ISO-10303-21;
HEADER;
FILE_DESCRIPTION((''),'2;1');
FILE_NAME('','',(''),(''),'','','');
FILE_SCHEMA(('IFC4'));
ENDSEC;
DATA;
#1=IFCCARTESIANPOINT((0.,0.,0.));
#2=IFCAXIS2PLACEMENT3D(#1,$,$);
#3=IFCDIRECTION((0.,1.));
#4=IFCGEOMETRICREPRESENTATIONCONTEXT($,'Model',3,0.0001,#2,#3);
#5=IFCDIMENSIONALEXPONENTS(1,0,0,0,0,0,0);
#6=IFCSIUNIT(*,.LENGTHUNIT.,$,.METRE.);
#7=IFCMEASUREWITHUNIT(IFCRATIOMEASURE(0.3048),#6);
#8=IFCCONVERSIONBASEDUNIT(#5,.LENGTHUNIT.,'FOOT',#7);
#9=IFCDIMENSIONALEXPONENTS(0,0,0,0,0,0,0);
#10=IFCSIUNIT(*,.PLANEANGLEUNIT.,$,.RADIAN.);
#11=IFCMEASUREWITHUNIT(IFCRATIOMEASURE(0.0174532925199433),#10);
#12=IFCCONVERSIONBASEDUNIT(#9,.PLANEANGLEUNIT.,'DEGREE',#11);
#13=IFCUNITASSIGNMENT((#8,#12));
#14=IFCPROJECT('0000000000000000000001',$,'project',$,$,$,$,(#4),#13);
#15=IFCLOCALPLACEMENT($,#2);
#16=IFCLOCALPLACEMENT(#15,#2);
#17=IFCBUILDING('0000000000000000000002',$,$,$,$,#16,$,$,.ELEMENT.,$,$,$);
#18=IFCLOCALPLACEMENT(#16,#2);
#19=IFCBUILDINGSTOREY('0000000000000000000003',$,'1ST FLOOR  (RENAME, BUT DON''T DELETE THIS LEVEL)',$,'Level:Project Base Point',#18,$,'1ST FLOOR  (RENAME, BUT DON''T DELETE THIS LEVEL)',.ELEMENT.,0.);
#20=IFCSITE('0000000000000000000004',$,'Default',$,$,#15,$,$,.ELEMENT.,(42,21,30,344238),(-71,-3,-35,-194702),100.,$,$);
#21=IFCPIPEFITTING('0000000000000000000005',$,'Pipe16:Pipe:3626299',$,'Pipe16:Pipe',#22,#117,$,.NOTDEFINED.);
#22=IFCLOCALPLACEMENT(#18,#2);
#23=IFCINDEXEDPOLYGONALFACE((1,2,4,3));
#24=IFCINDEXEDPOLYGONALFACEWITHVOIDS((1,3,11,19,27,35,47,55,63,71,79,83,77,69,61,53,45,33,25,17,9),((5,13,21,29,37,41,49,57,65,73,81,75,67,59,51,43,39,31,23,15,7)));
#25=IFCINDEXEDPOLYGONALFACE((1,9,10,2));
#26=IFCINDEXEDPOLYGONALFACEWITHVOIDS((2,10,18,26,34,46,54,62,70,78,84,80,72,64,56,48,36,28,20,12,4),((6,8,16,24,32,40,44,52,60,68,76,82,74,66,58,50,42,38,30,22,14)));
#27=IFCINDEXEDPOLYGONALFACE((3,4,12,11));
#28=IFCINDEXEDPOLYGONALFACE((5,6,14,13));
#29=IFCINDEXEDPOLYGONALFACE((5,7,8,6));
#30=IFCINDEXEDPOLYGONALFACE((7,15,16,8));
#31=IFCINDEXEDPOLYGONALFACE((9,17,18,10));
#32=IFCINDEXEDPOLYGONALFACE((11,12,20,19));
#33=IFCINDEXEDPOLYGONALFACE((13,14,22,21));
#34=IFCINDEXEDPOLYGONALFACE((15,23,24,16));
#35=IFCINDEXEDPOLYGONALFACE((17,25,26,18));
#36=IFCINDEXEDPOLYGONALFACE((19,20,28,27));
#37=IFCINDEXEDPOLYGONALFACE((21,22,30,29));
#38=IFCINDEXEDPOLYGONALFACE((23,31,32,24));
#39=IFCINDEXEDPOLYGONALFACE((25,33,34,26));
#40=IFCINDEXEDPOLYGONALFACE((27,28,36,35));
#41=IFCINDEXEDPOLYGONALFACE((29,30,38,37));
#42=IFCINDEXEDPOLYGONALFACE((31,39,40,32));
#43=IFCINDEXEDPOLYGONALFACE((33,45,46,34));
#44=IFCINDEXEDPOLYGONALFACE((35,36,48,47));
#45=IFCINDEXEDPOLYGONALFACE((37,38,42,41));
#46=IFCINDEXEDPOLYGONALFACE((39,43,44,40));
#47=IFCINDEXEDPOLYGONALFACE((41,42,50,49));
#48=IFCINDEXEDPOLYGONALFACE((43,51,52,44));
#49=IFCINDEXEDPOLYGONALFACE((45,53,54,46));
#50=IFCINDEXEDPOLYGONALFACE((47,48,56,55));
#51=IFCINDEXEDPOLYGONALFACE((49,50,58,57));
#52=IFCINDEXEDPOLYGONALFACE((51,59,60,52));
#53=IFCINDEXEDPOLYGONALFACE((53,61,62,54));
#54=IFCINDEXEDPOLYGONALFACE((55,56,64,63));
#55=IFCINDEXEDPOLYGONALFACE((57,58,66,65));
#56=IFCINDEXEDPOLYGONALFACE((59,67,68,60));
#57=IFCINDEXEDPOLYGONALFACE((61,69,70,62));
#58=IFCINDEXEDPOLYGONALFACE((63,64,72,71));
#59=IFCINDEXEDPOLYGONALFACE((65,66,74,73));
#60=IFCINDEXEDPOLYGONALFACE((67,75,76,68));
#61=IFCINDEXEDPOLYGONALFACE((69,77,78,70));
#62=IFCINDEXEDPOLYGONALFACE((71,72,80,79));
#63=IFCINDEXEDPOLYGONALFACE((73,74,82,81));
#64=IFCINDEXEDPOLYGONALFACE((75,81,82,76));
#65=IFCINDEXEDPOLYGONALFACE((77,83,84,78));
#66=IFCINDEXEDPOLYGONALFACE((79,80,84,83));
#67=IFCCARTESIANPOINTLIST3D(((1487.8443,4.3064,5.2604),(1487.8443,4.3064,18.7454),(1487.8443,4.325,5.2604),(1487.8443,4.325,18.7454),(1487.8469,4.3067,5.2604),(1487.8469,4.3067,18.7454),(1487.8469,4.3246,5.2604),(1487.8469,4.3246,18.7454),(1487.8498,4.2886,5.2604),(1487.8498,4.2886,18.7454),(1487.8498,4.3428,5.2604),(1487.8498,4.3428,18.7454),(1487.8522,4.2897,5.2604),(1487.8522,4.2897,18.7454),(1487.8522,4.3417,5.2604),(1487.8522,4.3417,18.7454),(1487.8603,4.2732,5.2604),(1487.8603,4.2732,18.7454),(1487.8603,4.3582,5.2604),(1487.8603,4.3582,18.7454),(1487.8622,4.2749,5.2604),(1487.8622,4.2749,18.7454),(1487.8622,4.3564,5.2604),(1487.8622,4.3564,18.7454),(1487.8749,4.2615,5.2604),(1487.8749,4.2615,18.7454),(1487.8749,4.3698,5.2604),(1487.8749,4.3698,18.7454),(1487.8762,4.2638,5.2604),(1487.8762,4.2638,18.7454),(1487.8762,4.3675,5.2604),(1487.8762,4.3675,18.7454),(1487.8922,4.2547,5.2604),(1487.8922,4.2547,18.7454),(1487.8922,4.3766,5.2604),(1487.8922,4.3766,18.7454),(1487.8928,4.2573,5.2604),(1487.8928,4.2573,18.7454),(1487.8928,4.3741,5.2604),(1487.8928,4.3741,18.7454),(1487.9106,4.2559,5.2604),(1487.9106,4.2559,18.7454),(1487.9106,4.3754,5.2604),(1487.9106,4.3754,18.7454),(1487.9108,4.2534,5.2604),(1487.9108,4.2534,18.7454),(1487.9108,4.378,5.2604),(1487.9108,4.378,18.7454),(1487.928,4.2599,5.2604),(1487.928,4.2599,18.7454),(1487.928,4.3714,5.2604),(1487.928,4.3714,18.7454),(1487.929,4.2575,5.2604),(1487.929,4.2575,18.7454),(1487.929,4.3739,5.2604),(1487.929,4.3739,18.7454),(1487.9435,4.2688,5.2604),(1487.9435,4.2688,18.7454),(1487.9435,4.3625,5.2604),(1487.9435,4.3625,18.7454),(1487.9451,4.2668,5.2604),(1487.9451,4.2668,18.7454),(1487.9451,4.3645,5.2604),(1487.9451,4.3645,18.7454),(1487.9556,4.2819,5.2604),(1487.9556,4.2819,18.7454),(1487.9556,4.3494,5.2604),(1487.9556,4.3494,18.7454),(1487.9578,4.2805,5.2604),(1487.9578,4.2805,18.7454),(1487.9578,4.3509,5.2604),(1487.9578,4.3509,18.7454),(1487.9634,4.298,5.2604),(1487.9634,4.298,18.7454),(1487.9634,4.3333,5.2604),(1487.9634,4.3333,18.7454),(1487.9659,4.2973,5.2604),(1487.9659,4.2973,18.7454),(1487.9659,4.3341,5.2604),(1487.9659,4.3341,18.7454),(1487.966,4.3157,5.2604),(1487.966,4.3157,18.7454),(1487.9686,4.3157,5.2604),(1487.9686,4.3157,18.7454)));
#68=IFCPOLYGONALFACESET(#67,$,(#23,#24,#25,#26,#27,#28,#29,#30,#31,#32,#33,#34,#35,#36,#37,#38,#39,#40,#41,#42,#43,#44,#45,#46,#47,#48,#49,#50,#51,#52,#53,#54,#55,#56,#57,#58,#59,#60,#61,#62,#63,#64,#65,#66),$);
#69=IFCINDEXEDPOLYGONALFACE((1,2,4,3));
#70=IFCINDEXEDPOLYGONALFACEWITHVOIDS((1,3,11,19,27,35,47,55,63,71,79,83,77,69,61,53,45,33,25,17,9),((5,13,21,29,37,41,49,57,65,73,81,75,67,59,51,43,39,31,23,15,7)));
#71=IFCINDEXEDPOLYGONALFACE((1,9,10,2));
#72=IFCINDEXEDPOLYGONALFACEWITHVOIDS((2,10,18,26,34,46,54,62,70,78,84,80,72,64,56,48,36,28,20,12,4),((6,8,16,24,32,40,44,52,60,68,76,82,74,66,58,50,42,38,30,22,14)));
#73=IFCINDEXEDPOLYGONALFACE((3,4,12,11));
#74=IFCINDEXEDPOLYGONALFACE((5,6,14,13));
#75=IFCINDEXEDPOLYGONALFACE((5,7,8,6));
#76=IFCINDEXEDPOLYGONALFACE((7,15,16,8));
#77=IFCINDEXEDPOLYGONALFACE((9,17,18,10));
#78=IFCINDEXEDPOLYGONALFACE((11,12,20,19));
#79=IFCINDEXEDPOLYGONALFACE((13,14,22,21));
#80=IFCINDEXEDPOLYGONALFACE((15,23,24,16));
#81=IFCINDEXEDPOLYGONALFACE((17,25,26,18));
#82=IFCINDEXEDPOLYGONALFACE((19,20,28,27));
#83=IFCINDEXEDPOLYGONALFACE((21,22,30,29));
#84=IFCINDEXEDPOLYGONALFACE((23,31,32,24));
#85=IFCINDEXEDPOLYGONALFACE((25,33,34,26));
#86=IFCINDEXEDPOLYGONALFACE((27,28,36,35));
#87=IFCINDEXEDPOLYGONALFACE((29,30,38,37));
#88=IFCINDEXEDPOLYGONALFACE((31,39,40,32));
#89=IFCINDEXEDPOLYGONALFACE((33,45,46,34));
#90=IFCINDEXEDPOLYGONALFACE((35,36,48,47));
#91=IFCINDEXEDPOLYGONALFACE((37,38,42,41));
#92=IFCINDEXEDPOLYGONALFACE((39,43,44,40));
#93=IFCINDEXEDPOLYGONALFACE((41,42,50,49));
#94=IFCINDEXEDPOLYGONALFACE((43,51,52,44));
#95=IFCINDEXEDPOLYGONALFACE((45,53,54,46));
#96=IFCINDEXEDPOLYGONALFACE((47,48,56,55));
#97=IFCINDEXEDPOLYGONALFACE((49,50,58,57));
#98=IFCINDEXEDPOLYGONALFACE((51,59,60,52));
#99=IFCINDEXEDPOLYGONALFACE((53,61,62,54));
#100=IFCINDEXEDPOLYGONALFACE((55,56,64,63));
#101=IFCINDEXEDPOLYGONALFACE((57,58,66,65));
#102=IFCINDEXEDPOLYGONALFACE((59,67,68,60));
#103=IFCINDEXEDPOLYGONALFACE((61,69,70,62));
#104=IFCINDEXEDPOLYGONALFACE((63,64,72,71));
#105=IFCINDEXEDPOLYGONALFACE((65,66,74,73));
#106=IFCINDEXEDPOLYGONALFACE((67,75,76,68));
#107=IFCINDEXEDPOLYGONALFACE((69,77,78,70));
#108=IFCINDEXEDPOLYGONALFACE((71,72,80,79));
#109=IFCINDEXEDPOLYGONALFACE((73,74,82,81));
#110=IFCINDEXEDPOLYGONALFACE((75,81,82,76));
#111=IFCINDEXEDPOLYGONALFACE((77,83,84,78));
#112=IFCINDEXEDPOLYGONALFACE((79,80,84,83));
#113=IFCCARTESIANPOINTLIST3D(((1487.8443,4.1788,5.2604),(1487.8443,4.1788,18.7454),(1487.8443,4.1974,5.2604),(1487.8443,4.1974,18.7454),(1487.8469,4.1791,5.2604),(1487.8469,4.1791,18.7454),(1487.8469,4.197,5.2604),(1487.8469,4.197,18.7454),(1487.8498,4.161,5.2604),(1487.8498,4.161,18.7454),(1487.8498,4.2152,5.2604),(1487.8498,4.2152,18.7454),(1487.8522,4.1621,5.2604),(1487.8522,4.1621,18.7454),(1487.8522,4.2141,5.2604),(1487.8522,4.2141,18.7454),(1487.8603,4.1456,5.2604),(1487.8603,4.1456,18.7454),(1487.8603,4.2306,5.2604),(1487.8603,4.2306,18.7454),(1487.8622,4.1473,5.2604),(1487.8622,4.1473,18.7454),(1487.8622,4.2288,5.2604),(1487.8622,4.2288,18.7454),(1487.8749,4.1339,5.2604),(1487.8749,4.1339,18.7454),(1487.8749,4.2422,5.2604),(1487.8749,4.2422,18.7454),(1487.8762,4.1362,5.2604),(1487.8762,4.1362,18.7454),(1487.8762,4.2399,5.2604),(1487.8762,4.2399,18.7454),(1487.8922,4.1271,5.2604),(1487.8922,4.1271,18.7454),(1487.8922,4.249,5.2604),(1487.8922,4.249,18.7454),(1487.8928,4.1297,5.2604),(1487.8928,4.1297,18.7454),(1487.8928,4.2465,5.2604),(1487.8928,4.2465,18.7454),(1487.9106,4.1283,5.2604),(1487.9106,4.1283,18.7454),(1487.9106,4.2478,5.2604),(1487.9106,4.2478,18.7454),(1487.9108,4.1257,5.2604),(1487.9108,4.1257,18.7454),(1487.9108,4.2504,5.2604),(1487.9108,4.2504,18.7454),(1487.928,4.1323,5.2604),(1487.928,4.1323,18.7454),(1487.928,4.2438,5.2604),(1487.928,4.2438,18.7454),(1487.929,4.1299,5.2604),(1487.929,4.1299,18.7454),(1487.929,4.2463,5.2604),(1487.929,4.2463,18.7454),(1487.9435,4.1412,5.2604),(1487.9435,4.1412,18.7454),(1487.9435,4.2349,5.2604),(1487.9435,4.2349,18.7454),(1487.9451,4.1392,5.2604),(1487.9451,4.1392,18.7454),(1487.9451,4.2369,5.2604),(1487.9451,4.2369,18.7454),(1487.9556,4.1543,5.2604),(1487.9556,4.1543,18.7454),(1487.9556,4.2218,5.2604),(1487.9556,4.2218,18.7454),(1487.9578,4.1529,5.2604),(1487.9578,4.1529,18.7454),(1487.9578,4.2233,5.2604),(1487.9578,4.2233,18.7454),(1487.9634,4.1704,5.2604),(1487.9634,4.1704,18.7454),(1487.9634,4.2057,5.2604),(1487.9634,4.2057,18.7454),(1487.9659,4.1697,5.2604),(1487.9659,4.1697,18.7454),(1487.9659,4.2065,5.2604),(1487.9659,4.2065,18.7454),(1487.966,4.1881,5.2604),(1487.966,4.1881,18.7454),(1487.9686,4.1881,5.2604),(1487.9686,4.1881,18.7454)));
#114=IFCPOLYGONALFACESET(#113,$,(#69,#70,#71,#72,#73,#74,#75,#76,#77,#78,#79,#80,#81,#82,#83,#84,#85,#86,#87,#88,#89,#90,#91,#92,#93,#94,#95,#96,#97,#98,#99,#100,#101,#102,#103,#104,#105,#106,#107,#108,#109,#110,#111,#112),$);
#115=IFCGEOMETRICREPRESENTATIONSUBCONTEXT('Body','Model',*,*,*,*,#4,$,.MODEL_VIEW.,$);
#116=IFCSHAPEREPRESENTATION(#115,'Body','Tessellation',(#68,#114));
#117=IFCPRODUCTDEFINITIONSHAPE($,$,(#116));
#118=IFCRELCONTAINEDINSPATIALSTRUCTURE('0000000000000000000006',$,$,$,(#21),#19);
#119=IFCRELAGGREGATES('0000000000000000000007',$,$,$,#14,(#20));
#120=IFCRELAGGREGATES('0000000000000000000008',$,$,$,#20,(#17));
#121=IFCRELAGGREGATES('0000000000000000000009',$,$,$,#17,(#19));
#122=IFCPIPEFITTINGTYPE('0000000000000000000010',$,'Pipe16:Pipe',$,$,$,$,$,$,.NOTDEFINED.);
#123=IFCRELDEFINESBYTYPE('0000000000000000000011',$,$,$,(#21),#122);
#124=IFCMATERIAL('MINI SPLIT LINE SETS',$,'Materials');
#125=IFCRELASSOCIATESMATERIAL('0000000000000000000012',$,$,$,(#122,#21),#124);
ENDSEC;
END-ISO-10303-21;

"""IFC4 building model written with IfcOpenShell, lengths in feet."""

from ifc_helpers import new_model, entity, si_unit, converted_unit, direction, frame, origin, origin_2d_with_axis, place, context, subcontext, project, spatial, hollow_circle, extrude, source, transform, mapped, material, type_object, type_shapes, element, save


model = new_model("IFC4")

# Units and contexts
model_context = context("Model", 3, precision=0.0001, world=origin(), true_north=direction((0.0, 1.0)))
body_context = subcontext(model_context, "Body", "Model", "MODEL_VIEW")
ifc_project = project(units=[converted_unit("LENGTHUNIT", "FOOT", entity("IfcRatioMeasure", 0.3048), si_unit("LENGTHUNIT", "METRE"), dimensions=[1, 0, 0, 0, 0, 0, 0]), converted_unit("PLANEANGLEUNIT", "DEGREE", entity("IfcRatioMeasure", 0.0174532925199433), si_unit("PLANEANGLEUNIT", "RADIAN"), dimensions=[0, 0, 0, 0, 0, 0, 0])], contexts=[model_context])

# Site, building, storey
site_placement = place(None, origin())
site = spatial("IfcSite", under=ifc_project, at=site_placement, Name="Default", CompositionType="ELEMENT", RefLatitude=(42, 21, 30, 344238), RefLongitude=(-71, -3, -35, -194702), RefElevation=100.0)
building_placement = place(site_placement, origin())
building = spatial("IfcBuilding", under=site, at=building_placement, CompositionType="ELEMENT")
storey_placement = place(building_placement, origin())
storey = spatial("IfcBuildingStorey", under=building, at=storey_placement, Name="1ST FLOOR  (RENAME, BUT DON'T DELETE THIS LEVEL)", ObjectType="Level:Project Base Point", LongName="1ST FLOOR  (RENAME, BUT DON'T DELETE THIS LEVEL)", CompositionType="ELEMENT", Elevation=0.0)

# Shared definitions
ifc_material_1 = material(Name="MINI SPLIT LINE SETS", Category="Materials")

# Pipe fitting
pipe_fitting_type_1 = type_object("IfcPipeFittingType", Name="Pipe16:Pipe", PredefinedType="NOTDEFINED", material=ifc_material_1)
shared_shape_1 = source(origin(), body_context, "Body", "SweptSolid", [
    extrude(hollow_circle(Radius=0.0625, WallThickness=0.0026, at=origin_2d_with_axis()), frame((0.0677, 0.1953, 0.0)), (0.0, 0.0, 1.0), 13.485),
    extrude(hollow_circle(Radius=0.0625, WallThickness=0.0026, at=origin_2d_with_axis()), frame((0.0677, 0.0677, 0.0)), (0.0, 0.0, 1.0), 13.485),
])
type_shapes(pipe_fitting_type_1, [shared_shape_1])
pipe_fitting_1_placement = place(storey_placement, frame((1487.8384, 4.1203, 5.2604)))
element("IfcPipeFitting", 1, at=pipe_fitting_1_placement, inside=storey, type_object=pipe_fitting_type_1, material=ifc_material_1, Name="Pipe16:Pipe:3626299", ObjectType="Pipe16:Pipe", PredefinedType="NOTDEFINED", context=body_context, shape_type="MappedRepresentation", body=[
    mapped(shared_shape_1, transform((0.0, 0.0, 0.0), scale=1.0)),
])

save(model, "model.ifc")
